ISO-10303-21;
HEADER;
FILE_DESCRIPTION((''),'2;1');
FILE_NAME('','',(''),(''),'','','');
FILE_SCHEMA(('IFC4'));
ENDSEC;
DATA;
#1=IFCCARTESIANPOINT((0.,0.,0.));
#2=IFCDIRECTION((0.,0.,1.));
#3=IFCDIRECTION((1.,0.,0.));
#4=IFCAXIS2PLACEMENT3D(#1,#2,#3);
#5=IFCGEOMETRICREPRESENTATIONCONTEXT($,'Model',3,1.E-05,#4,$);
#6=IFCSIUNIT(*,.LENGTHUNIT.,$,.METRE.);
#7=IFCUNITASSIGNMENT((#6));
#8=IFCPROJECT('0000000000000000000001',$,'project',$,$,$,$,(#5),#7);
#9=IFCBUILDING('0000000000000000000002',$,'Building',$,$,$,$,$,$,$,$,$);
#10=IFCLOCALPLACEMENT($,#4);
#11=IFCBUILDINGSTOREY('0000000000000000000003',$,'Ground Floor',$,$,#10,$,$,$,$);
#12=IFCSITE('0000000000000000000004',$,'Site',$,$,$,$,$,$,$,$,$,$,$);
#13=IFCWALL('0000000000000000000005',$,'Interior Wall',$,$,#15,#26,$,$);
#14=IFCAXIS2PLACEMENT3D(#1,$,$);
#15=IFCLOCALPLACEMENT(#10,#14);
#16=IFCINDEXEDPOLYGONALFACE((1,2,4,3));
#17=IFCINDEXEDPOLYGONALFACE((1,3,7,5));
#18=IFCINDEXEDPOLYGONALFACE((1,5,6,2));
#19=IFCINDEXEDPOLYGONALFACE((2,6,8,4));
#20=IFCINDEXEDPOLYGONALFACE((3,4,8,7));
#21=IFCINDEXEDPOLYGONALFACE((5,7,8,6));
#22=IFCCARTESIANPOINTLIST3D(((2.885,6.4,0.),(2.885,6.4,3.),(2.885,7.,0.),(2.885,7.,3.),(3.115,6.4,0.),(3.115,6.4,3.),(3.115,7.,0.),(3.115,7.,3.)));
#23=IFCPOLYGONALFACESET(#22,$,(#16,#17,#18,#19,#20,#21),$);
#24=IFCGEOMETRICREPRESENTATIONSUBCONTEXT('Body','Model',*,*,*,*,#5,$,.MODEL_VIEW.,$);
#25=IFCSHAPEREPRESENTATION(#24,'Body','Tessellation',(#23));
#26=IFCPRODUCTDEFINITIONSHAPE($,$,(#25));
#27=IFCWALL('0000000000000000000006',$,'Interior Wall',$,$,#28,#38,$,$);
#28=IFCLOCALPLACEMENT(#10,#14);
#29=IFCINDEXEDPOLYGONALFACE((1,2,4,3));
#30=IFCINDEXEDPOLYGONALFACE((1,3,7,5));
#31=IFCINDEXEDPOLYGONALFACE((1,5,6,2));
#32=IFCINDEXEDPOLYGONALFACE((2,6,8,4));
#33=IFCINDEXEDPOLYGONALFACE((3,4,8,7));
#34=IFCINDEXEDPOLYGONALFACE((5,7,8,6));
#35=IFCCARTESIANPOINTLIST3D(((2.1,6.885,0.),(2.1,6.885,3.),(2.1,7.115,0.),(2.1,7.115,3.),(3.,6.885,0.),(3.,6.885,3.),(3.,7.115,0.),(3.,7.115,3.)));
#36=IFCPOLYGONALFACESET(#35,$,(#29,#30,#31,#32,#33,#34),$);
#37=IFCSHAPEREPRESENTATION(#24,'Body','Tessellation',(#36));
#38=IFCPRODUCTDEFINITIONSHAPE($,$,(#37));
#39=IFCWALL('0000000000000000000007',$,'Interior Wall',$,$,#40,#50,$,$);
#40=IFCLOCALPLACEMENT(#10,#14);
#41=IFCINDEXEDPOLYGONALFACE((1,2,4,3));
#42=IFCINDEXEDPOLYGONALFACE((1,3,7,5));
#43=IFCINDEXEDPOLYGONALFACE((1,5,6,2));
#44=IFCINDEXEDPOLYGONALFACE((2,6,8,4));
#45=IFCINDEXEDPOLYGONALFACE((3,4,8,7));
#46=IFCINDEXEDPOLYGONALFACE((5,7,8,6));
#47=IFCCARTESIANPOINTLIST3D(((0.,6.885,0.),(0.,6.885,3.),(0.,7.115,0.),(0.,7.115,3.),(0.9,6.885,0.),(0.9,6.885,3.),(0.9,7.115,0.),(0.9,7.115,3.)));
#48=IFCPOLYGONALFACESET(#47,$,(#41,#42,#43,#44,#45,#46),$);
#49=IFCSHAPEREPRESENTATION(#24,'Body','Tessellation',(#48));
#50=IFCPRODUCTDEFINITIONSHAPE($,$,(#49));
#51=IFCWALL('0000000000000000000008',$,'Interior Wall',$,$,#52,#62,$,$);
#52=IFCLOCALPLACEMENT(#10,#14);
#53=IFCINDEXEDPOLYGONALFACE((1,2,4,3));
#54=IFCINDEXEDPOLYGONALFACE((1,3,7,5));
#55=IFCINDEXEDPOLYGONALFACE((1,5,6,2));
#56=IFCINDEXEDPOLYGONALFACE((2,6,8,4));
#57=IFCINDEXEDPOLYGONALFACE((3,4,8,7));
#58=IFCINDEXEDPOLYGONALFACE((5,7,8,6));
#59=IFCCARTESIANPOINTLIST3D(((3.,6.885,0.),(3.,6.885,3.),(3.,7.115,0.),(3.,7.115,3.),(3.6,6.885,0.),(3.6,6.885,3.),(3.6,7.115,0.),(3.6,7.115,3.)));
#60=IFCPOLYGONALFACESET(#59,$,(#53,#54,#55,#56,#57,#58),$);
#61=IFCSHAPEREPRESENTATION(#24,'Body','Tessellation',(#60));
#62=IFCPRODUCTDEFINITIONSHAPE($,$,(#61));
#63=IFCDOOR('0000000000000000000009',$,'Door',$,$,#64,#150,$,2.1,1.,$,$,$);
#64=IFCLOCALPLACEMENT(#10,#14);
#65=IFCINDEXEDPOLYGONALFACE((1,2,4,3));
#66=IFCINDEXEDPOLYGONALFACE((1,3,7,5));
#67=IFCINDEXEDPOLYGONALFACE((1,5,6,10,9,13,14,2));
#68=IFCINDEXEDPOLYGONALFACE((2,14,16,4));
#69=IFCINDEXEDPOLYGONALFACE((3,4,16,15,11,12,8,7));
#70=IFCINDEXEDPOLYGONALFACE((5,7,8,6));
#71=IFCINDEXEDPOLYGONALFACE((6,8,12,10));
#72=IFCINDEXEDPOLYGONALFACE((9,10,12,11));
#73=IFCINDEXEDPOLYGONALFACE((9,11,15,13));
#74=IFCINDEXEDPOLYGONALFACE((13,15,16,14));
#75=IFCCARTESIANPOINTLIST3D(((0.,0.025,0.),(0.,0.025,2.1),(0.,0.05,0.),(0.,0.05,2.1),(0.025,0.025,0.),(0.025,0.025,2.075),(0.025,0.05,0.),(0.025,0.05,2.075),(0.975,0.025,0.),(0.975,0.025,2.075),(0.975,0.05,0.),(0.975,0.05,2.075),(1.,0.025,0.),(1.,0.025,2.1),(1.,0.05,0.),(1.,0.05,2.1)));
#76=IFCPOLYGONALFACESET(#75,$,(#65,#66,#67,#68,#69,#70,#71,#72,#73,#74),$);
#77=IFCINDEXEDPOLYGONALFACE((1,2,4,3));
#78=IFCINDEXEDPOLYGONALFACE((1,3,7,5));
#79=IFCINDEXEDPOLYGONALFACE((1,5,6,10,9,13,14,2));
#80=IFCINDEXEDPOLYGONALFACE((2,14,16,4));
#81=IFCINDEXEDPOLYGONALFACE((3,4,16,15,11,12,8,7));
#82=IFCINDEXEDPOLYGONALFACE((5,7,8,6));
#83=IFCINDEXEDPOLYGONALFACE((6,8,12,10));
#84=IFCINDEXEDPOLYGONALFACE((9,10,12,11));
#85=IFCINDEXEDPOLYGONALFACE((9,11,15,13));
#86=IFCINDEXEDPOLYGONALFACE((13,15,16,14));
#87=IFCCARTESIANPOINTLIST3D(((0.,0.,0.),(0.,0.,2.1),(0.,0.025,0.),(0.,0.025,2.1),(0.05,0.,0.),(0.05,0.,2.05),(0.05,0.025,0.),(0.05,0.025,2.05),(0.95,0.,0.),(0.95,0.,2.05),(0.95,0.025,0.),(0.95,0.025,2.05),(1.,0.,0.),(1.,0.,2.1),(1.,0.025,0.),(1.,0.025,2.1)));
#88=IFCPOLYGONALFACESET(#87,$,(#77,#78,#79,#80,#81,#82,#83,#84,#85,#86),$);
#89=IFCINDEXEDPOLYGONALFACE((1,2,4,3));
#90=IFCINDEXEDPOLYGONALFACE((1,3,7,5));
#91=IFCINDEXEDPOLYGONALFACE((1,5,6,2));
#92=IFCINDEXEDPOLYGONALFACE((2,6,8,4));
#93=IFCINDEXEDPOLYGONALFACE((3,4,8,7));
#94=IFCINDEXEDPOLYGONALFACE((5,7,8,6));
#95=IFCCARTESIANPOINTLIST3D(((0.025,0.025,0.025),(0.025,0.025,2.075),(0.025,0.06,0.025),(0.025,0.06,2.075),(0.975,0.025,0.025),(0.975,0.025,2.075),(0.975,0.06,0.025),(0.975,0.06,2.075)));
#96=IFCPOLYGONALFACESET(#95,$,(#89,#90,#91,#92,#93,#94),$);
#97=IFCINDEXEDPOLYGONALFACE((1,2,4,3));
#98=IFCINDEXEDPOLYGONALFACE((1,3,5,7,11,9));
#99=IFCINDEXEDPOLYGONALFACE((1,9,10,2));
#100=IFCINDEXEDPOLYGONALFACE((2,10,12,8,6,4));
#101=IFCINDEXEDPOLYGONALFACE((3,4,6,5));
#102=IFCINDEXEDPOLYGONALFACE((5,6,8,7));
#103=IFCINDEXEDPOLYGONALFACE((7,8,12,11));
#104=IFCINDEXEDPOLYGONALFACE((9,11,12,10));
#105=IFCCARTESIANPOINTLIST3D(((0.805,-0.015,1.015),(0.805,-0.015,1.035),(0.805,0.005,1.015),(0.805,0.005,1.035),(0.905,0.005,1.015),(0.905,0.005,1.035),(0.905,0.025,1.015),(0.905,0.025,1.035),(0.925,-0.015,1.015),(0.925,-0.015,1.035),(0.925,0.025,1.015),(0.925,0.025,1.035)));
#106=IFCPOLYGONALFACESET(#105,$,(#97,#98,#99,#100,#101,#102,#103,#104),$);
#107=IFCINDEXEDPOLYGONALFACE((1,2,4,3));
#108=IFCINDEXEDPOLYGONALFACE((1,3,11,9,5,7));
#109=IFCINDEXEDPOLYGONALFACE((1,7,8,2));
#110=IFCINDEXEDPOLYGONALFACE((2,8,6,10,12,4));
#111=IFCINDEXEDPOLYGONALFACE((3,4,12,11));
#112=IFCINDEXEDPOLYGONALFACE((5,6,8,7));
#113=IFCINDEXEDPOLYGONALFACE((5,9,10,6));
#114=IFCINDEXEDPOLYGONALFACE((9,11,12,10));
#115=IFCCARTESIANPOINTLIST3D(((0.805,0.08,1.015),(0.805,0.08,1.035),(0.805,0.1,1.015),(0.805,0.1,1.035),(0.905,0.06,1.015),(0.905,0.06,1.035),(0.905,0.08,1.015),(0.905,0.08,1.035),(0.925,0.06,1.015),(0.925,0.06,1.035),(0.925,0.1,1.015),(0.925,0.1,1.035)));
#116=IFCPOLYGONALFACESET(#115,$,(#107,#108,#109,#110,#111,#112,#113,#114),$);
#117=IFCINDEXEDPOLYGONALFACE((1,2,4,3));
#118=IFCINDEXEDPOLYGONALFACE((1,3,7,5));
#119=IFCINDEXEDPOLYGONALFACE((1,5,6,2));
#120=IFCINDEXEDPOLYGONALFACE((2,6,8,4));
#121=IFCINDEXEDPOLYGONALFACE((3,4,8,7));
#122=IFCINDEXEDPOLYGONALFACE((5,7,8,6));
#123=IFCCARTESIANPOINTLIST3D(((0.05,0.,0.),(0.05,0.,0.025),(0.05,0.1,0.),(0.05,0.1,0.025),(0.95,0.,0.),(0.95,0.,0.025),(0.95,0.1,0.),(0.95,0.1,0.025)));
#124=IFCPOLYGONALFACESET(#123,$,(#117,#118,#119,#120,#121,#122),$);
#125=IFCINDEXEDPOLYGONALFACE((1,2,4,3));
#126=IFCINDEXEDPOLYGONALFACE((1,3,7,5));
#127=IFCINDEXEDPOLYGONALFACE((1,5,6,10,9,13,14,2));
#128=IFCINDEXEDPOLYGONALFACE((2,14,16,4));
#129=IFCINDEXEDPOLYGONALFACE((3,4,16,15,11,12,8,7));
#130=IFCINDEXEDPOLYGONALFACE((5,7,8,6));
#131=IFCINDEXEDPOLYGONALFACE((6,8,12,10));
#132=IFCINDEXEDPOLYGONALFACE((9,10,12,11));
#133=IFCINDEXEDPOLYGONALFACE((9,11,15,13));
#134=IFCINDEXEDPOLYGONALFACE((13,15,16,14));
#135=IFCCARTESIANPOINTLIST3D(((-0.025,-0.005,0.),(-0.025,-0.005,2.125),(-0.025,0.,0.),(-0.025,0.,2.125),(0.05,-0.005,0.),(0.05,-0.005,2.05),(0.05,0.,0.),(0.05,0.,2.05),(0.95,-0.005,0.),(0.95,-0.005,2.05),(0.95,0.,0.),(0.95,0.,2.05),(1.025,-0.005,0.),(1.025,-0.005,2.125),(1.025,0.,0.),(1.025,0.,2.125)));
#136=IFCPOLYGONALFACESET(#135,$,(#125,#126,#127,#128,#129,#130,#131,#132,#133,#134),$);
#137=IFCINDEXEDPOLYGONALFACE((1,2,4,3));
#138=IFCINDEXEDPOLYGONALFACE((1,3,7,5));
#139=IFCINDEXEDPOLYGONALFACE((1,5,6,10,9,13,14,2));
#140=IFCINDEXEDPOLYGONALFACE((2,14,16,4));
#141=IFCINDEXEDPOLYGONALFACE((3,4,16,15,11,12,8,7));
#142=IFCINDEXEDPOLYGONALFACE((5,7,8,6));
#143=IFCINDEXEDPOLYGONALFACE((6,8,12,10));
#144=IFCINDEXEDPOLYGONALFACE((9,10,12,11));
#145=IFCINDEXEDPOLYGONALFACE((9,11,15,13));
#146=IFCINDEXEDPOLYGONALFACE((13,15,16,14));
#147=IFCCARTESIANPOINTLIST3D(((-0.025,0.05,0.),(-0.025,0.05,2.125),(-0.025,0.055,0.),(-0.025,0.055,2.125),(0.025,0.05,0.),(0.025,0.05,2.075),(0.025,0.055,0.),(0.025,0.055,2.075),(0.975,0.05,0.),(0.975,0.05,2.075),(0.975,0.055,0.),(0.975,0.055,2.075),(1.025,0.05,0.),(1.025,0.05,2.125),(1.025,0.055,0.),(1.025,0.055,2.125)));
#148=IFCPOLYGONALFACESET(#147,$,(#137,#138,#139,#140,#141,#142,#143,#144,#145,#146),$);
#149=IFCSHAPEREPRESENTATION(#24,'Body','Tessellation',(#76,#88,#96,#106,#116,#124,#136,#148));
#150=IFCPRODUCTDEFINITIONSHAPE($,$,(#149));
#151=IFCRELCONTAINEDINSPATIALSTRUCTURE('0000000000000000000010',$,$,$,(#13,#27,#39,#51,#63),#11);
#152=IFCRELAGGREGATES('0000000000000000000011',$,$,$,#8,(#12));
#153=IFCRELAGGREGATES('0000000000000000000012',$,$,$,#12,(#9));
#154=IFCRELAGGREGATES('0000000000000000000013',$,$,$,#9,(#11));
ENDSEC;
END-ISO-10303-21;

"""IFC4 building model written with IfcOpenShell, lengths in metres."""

from ifc_helpers import new_model, si_unit, frame, origin_with_axes, place, context, subcontext, project, spatial, line, indexed_curve, outline, extrude, element, save


model = new_model("IFC4")

# Units and contexts
model_context = context("Model", 3, precision=1e-05, world=origin_with_axes())
body_context = subcontext(model_context, "Body", "Model", "MODEL_VIEW")
ifc_project = project(units=[si_unit("LENGTHUNIT", "METRE")], contexts=[model_context])

# Site, building, storey
site = spatial("IfcSite", under=ifc_project, Name="Site")
building = spatial("IfcBuilding", under=site, Name="Building")
storey_placement = place(None, origin_with_axes())
storey = spatial("IfcBuildingStorey", under=building, at=storey_placement, Name="Ground Floor")

# Walls
for number, where, z_axis, x_axis, name in (
    (1, (3.0, 6.4, 0.0), (0.0, 0.0, 1.0), (0.0, 1.0, 0.0), "Interior Wall"),
):
    element("IfcWall", number, at=place(storey_placement, frame(where, z_axis=z_axis, x_axis=x_axis)), inside=storey, Name=name, context=body_context, shape_type="SweptSolid", body=[
        extrude(outline(indexed_curve([(0.0, 0.0), (0.0, 0.23), (0.6, 0.23), (0.6, 0.0), (0.0, 0.0)], self_intersect=False)), frame((0.0, -0.115, 0.0), z_axis=(0.0, 0.0, 1.0), x_axis=(1.0, 0.0, 0.0)), (0.0, 0.0, 1.0), 3.0),
    ])
for number, where, z_axis, x_axis, name in (
    (2, (3.0, 7.0, 0.0), (0.0, 0.0, 1.0), (-1.0, 0.0, 0.0), "Interior Wall"),
    (3, (0.9, 7.0, 0.0), (0.0, 0.0, 1.0), (-1.0, 0.0, 0.0), "Interior Wall"),
):
    element("IfcWall", number, at=place(storey_placement, frame(where, z_axis=z_axis, x_axis=x_axis)), inside=storey, Name=name, context=body_context, shape_type="SweptSolid", body=[
        extrude(outline(indexed_curve([(0.0, 0.0), (0.0, 0.23), (0.9, 0.23), (0.9, 0.0), (0.0, 0.0)], self_intersect=False)), frame((0.0, -0.115, 0.0), z_axis=(0.0, 0.0, 1.0), x_axis=(1.0, 0.0, 0.0)), (0.0, 0.0, 1.0), 3.0),
    ])
wall_1_placement = place(storey_placement, frame((3.6, 7.0, 0.0), z_axis=(0.0, 0.0, 1.0), x_axis=(-1.0, 0.0, 0.0)))
element("IfcWall", 4, at=wall_1_placement, inside=storey, Name="Interior Wall", context=body_context, shape_type="SweptSolid", body=[
    extrude(outline(indexed_curve([(0.0, 0.0), (0.0, 0.23), (0.6, 0.23), (0.6, 0.0), (0.0, 0.0)], self_intersect=False)), frame((0.0, -0.115, 0.0), z_axis=(0.0, 0.0, 1.0), x_axis=(1.0, 0.0, 0.0)), (0.0, 0.0, 1.0), 3.0),
])

# Door
door_1_placement = place(storey_placement, origin_with_axes())
element("IfcDoor", 5, at=door_1_placement, inside=storey, Name="Door", OverallHeight=2.1, OverallWidth=1.0, context=body_context, shape_type="SweptSolid", body=[
    extrude(outline(indexed_curve([(0.0, 0.0), (0.0, 2.1), (1.0, 2.1), (1.0, 0.0), (0.975, 0.0), (0.975, 2.075), (0.025, 2.075), (0.025, 0.0)], segments=[line(1, 2, 3, 4, 5, 6, 7, 8, 1)])), frame((0.0, 0.025, 0.0), z_axis=(0.0, -1.0, 0.0), x_axis=(1.0, 0.0, 0.0)), (0.0, 0.0, -1.0), 0.025),
    extrude(outline(indexed_curve([(0.0, 0.0), (0.0, 2.1), (1.0, 2.1), (1.0, 0.0), (0.95, 0.0), (0.95, 2.05), (0.05, 2.05), (0.05, 0.0)], segments=[line(1, 2, 3, 4, 5, 6, 7, 8, 1)])), frame((0.0, 0.0, 0.0), z_axis=(0.0, -1.0, 0.0), x_axis=(1.0, 0.0, 0.0)), (0.0, 0.0, -1.0), 0.025),
    extrude(outline(indexed_curve([(0.0, 0.0), (0.95, 0.0), (0.95, 0.035), (0.0, 0.035)], segments=[line(1, 2, 3, 4, 1)])), frame((0.025, 0.025, 0.025), z_axis=(0.0, 0.0, 1.0), x_axis=(1.0, 0.0, 0.0)), (0.0, 0.0, 1.0), 2.05),
    extrude(outline(indexed_curve([(0.0, 0.0), (0.0, -0.04), (-0.12, -0.04), (-0.12, -0.02), (-0.02, -0.02), (-0.02, 0.0)], segments=[line(1, 2, 3, 4, 5, 6, 1)])), frame((0.925, 0.025, 1.015), z_axis=(0.0, 0.0, 1.0), x_axis=(1.0, 0.0, 0.0)), (0.0, 0.0, 1.0), 0.02),
    extrude(outline(indexed_curve([(0.0, 0.0), (0.0, 0.04), (-0.12, 0.04), (-0.12, 0.02), (-0.02, 0.02), (-0.02, 0.0)], segments=[line(1, 2, 3, 4, 5, 6, 1)])), frame((0.925, 0.06, 1.015), z_axis=(0.0, 0.0, 1.0), x_axis=(1.0, 0.0, 0.0)), (0.0, 0.0, 1.0), 0.02),
    extrude(outline(indexed_curve([(0.0, 0.0), (0.9, 0.0), (0.9, 0.1), (0.0, 0.1)], segments=[line(1, 2, 3, 4, 1)])), frame((0.05, 0.0, 0.0), z_axis=(0.0, 0.0, 1.0), x_axis=(1.0, 0.0, 0.0)), (0.0, 0.0, 1.0), 0.025),
    extrude(outline(indexed_curve([(0.0, 0.0), (0.0, 2.125), (1.05, 2.125), (1.05, 0.0), (0.975, 0.0), (0.975, 2.05), (0.075, 2.05), (0.075, 0.0)], segments=[line(1, 2, 3, 4, 5, 6, 7, 8, 1)])), frame((-0.025, -0.005, 0.0), z_axis=(0.0, -1.0, 0.0), x_axis=(1.0, 0.0, 0.0)), (0.0, 0.0, -1.0), 0.005),
    extrude(outline(indexed_curve([(0.0, 0.0), (0.0, 2.125), (1.05, 2.125), (1.05, 0.0), (1.0, 0.0), (1.0, 2.075), (0.05, 2.075), (0.05, 0.0)], segments=[line(1, 2, 3, 4, 5, 6, 7, 8, 1)])), frame((-0.025, 0.05, 0.0), z_axis=(0.0, -1.0, 0.0), x_axis=(1.0, 0.0, 0.0)), (0.0, 0.0, -1.0), 0.005),
])

save(model, "model.ifc")
